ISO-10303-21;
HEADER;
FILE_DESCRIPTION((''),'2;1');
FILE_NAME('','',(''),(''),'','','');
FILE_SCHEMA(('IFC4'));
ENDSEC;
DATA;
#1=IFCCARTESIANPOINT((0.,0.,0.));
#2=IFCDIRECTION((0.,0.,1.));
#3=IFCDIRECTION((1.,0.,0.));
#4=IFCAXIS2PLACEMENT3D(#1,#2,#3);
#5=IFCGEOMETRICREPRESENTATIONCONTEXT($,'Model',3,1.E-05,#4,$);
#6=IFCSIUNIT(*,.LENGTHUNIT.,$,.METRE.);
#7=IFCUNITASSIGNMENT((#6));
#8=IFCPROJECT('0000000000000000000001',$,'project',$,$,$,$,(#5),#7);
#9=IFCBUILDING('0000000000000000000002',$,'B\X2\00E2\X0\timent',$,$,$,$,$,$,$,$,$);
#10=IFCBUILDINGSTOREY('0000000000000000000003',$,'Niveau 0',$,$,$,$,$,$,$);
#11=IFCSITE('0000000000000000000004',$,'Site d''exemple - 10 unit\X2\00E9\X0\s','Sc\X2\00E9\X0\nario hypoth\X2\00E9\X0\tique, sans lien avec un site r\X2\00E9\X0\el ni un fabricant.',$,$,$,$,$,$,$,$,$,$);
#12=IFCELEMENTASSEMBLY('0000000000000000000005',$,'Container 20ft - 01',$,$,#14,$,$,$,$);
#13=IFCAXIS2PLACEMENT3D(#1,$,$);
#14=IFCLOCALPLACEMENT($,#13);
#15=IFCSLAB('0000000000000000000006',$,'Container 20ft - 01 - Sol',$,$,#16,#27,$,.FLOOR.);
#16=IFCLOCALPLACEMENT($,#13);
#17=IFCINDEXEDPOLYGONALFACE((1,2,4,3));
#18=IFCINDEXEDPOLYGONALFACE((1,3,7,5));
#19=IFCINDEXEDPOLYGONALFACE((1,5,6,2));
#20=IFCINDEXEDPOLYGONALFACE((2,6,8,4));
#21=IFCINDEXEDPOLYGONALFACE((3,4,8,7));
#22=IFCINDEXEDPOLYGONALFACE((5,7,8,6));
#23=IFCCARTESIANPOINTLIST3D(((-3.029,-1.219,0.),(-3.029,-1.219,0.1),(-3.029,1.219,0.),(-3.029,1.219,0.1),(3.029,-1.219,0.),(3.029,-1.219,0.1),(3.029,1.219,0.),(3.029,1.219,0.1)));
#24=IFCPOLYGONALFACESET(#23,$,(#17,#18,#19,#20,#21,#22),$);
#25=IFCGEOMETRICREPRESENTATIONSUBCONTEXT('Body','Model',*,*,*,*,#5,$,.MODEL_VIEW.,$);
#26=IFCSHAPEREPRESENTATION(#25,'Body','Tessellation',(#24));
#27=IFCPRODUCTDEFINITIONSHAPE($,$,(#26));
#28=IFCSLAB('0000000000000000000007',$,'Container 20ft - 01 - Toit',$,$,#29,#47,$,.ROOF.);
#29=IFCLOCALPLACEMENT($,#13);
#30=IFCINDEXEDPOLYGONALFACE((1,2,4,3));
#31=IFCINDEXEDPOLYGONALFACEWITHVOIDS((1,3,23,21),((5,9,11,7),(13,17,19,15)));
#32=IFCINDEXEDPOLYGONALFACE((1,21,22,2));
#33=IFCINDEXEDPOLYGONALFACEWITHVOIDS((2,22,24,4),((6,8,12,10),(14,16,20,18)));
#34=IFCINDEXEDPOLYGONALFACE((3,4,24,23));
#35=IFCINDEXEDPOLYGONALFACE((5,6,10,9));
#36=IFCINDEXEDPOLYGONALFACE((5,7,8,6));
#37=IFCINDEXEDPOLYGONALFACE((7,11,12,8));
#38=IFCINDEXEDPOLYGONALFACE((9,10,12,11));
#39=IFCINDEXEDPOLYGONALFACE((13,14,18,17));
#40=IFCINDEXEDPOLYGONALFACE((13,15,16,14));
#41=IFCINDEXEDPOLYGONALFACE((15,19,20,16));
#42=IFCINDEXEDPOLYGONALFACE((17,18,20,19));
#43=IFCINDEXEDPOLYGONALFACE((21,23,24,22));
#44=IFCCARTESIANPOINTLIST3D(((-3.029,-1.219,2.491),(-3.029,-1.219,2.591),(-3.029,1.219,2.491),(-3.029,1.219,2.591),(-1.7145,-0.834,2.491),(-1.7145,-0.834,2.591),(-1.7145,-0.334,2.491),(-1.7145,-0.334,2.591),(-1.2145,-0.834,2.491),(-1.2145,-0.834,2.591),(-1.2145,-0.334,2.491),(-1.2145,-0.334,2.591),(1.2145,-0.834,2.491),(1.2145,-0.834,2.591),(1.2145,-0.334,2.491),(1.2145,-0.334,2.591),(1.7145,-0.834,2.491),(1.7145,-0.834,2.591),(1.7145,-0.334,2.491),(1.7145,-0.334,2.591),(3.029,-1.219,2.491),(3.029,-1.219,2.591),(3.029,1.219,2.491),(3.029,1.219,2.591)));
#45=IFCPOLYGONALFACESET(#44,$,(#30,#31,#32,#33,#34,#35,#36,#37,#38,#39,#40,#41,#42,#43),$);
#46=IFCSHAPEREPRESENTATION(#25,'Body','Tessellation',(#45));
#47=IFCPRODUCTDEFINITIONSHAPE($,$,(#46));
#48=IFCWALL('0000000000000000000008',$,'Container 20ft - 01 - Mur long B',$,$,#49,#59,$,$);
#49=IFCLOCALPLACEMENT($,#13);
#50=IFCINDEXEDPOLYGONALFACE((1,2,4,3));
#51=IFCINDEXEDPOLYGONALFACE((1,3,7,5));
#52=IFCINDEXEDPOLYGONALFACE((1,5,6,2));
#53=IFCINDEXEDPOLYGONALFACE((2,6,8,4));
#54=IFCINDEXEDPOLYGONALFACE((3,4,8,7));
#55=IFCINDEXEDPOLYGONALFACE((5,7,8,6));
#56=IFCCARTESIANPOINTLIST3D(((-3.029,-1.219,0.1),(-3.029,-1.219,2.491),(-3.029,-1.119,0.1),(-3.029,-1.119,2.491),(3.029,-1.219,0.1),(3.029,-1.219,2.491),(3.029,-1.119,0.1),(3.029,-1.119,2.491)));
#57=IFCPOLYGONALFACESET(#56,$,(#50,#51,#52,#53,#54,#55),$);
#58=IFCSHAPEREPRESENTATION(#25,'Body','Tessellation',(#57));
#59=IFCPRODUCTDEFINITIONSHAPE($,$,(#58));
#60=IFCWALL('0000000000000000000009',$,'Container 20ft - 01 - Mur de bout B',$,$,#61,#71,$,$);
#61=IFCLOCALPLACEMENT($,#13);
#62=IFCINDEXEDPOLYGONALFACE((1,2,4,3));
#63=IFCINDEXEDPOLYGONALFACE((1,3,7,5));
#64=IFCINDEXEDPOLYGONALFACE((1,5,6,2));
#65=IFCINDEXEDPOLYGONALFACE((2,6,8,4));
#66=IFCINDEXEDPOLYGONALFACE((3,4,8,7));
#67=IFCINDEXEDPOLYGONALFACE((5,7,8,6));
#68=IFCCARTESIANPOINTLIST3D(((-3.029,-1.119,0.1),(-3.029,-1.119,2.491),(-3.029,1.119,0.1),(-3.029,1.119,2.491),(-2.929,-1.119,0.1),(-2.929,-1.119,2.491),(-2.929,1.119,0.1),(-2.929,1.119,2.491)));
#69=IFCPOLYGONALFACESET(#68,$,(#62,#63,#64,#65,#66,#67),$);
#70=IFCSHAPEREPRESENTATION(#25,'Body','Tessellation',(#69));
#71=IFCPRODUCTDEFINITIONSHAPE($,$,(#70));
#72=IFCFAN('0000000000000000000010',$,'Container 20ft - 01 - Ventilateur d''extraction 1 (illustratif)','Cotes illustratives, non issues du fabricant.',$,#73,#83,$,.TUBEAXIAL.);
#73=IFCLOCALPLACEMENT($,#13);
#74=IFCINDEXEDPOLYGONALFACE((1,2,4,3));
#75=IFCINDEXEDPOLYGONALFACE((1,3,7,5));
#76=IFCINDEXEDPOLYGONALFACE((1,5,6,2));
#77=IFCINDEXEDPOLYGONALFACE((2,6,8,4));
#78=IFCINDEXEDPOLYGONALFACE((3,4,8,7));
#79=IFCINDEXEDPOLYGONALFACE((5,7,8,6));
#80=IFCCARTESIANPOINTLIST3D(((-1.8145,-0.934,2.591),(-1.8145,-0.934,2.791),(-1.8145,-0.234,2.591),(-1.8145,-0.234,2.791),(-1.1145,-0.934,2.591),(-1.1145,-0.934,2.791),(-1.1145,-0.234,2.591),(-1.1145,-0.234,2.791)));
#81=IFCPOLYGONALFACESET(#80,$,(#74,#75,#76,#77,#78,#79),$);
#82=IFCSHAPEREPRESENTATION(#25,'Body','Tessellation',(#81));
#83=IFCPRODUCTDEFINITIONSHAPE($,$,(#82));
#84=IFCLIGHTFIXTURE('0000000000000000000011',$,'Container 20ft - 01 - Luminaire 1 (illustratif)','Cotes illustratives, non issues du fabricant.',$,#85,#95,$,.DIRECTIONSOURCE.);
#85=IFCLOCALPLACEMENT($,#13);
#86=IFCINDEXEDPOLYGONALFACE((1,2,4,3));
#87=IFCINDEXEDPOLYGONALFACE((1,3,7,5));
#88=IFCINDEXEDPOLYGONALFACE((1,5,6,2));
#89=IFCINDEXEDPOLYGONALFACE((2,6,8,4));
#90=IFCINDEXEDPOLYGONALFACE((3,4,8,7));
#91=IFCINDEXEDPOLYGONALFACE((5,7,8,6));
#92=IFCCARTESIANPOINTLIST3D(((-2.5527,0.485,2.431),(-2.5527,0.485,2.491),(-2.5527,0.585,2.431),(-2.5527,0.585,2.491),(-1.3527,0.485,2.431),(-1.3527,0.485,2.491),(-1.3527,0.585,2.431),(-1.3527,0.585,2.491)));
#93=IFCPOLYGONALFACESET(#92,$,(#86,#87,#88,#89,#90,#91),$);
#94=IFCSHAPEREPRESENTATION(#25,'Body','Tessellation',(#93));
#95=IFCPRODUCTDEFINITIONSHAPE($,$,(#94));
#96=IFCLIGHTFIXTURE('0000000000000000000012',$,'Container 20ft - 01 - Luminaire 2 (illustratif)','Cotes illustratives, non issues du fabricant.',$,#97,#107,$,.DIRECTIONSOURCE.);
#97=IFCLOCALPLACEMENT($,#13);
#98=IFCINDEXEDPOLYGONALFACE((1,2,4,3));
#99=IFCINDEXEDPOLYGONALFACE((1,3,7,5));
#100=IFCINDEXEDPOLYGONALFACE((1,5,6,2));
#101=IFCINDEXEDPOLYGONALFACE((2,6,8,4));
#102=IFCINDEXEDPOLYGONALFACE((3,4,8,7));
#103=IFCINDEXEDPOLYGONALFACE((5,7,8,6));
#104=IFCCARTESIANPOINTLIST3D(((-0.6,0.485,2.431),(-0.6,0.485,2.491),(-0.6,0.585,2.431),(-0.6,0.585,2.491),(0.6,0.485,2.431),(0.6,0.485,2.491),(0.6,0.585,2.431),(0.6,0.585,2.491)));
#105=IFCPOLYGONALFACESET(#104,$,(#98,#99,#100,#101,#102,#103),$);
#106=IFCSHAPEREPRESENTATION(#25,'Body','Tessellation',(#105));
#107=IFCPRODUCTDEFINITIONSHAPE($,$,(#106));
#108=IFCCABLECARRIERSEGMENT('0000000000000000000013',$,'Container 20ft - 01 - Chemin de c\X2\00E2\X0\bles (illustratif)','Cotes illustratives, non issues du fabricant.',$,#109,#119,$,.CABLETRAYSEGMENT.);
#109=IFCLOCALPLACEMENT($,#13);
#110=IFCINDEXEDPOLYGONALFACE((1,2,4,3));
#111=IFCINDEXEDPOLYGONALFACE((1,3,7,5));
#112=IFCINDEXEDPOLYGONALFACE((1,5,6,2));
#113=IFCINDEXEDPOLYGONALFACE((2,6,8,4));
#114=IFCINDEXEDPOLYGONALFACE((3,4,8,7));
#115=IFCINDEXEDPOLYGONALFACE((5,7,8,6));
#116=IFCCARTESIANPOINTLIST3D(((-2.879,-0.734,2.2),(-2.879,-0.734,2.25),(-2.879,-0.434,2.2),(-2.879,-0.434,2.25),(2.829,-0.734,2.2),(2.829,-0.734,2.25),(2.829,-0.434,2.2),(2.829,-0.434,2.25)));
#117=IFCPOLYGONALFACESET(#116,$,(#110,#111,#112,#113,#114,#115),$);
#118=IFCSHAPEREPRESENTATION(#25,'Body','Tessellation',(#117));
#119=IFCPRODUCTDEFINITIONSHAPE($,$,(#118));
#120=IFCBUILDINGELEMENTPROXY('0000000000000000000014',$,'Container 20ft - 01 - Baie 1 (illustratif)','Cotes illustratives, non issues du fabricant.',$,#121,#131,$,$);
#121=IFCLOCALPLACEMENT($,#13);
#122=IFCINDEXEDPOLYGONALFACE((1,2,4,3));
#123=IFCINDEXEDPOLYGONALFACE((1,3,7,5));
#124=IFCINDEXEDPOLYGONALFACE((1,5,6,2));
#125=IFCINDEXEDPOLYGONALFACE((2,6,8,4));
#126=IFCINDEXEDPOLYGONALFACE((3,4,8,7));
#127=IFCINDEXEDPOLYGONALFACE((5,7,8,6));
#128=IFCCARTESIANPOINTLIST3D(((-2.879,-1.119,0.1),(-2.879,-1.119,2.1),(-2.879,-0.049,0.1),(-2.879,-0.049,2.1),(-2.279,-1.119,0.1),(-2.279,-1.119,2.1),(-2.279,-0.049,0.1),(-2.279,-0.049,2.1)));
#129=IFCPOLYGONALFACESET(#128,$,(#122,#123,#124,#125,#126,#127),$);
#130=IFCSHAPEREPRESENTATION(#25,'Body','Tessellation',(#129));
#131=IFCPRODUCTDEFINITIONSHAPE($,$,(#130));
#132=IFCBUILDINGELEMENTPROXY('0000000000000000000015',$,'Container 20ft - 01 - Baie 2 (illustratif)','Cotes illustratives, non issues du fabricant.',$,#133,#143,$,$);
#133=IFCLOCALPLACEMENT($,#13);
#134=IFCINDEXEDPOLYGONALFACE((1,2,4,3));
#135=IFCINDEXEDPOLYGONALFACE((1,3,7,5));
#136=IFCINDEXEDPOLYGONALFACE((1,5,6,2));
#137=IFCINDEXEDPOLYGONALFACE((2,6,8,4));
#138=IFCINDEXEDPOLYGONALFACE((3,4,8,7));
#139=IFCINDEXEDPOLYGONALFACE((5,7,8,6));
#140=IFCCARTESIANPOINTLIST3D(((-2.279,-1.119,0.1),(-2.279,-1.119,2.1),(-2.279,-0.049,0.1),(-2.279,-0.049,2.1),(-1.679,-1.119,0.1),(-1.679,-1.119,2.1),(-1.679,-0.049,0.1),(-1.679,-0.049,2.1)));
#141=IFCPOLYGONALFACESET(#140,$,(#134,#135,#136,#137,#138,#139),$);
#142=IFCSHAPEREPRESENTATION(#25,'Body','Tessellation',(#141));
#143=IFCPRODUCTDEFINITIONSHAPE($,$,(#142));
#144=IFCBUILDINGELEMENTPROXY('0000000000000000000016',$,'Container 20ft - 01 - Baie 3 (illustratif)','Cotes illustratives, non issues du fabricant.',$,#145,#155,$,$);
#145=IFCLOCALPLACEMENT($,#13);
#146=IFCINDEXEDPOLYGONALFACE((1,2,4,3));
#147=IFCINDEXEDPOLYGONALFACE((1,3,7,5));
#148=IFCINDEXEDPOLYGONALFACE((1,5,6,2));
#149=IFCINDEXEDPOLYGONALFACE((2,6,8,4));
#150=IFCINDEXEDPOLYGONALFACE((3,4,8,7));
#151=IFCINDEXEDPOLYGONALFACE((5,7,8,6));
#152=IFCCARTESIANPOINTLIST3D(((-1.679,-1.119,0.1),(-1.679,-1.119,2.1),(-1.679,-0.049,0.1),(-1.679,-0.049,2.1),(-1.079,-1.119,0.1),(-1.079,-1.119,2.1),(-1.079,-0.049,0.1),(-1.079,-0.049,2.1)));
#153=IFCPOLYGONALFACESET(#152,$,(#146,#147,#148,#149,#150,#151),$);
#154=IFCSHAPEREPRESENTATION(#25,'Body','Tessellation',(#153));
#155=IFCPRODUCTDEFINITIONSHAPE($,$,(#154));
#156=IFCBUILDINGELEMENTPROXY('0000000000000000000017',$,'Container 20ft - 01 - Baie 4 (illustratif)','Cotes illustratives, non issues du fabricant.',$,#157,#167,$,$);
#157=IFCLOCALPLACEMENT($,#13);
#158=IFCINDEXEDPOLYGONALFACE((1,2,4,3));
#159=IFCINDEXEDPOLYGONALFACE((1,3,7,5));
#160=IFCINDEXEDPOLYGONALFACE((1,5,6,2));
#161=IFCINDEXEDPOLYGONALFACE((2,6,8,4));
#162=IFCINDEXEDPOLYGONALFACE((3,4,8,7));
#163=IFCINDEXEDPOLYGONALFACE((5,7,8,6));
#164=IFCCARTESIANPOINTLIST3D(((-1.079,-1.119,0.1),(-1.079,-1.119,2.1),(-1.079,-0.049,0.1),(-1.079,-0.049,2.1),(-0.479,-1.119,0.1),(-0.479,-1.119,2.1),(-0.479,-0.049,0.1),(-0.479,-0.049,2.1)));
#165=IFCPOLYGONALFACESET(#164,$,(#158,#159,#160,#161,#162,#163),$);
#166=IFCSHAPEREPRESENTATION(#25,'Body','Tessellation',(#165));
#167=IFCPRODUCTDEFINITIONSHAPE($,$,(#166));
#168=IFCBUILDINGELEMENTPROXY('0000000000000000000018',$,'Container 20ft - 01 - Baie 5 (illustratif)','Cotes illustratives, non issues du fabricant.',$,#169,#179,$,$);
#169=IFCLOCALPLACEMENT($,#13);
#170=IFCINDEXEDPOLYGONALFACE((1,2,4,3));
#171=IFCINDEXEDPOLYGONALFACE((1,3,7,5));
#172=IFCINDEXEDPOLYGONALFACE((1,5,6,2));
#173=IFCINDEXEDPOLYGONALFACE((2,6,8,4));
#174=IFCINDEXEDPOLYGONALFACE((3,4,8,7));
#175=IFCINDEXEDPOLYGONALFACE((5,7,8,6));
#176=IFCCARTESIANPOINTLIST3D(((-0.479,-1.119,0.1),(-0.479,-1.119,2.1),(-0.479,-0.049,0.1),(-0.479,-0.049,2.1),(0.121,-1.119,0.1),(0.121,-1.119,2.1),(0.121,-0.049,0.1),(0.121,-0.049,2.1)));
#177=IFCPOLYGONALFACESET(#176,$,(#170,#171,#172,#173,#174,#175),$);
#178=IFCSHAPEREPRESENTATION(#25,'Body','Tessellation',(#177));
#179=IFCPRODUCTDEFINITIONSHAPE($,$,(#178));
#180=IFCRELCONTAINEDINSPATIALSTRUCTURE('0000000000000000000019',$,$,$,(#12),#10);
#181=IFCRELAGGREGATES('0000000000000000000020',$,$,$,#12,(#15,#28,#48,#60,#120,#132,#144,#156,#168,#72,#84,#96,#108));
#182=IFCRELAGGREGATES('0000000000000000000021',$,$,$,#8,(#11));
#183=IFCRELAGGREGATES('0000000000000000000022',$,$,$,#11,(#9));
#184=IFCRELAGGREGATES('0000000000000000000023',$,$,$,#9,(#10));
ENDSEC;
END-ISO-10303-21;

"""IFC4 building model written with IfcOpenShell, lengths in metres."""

from ifc_helpers import new_model, si_unit, frame, origin_with_axes, place, context, subcontext, project, spatial, rectangle, extrude, element, aggregate, save


model = new_model("IFC4")

# Units and contexts
model_context = context("Model", 3, precision=1e-05, world=origin_with_axes())
body_context = subcontext(model_context, "Body", "Model", "MODEL_VIEW")
ifc_project = project(units=[si_unit("LENGTHUNIT", "METRE")], contexts=[model_context])

# Site, building, storey
site = spatial("IfcSite", under=ifc_project, Name="Site d'exemple - 10 unités", Description="Scénario hypothétique, sans lien avec un site réel ni un fabricant.")
building = spatial("IfcBuilding", under=site, Name="Bâtiment")
storey = spatial("IfcBuildingStorey", under=building, Name="Niveau 0")

# Element assembly, slabs, openings, walls, fan, light fixtures, cable carrier segment, building element proxies
assembly = element("IfcElementAssembly", 1, inside=storey, Name="Container 20ft - 01")
slab_1_placement = place(None, origin_with_axes())
slab_1 = element("IfcSlab", 2, at=slab_1_placement, Name="Container 20ft - 01 - Sol", PredefinedType="FLOOR", context=body_context, shape_type="SweptSolid", body=[
    extrude(rectangle(XDim=6.058, YDim=2.438), origin_with_axes(), (0.0, 0.0, 1.0), 0.1),
])
slab_2_placement = place(None, frame((0.0, 0.0, 2.491), z_axis=(0.0, 0.0, 1.0), x_axis=(1.0, 0.0, 0.0)))
slab_2 = element("IfcSlab", 3, at=slab_2_placement, Name="Container 20ft - 01 - Toit", PredefinedType="ROOF", context=body_context, shape_type="SweptSolid", body=[
    extrude(rectangle(XDim=6.058, YDim=2.438), origin_with_axes(), (0.0, 0.0, 1.0), 0.1),
])
opening_1_placement = place(None, frame((-1.4645, -0.584, 2.441), z_axis=(0.0, 0.0, 1.0), x_axis=(1.0, 0.0, 0.0)))
element("IfcOpeningElement", 4, at=opening_1_placement, cuts=slab_2, PredefinedType="OPENING", context=body_context, shape_type="SweptSolid", body=[
    extrude(rectangle(XDim=0.5, YDim=0.5), origin_with_axes(), (0.0, 0.0, 1.0), 0.2),
])
opening_2_placement = place(None, frame((1.4645, -0.584, 2.441), z_axis=(0.0, 0.0, 1.0), x_axis=(1.0, 0.0, 0.0)))
element("IfcOpeningElement", 5, at=opening_2_placement, cuts=slab_2, PredefinedType="OPENING", context=body_context, shape_type="SweptSolid", body=[
    extrude(rectangle(XDim=0.5, YDim=0.5), origin_with_axes(), (0.0, 0.0, 1.0), 0.2),
])
wall_1_placement = place(None, frame((0.0, -1.169, 0.1), z_axis=(0.0, 0.0, 1.0), x_axis=(1.0, 0.0, 0.0)))
wall_1 = element("IfcWall", 6, at=wall_1_placement, Name="Container 20ft - 01 - Mur long B", context=body_context, shape_type="SweptSolid", body=[
    extrude(rectangle(XDim=6.058, YDim=0.1), origin_with_axes(), (0.0, 0.0, 1.0), 2.391),
])
wall_2_placement = place(None, frame((-2.979, 0.0, 0.1), z_axis=(0.0, 0.0, 1.0), x_axis=(1.0, 0.0, 0.0)))
wall_2 = element("IfcWall", 7, at=wall_2_placement, Name="Container 20ft - 01 - Mur de bout B", context=body_context, shape_type="SweptSolid", body=[
    extrude(rectangle(XDim=0.1, YDim=2.238), origin_with_axes(), (0.0, 0.0, 1.0), 2.391),
])
fan_placement = place(None, frame((-1.4645, -0.584, 2.591), z_axis=(0.0, 0.0, 1.0), x_axis=(1.0, 0.0, 0.0)))
fan = element("IfcFan", 8, at=fan_placement, Name="Container 20ft - 01 - Ventilateur d'extraction 1 (illustratif)", Description="Cotes illustratives, non issues du fabricant.", PredefinedType="TUBEAXIAL", context=body_context, shape_type="SweptSolid", body=[
    extrude(rectangle(XDim=0.7, YDim=0.7), origin_with_axes(), (0.0, 0.0, 1.0), 0.2),
])
light_fixture_1_placement = place(None, frame((-1.9527, 0.535, 2.431), z_axis=(0.0, 0.0, 1.0), x_axis=(1.0, 0.0, 0.0)))
light_fixture_1 = element("IfcLightFixture", 9, at=light_fixture_1_placement, Name="Container 20ft - 01 - Luminaire 1 (illustratif)", Description="Cotes illustratives, non issues du fabricant.", PredefinedType="DIRECTIONSOURCE", context=body_context, shape_type="SweptSolid", body=[
    extrude(rectangle(XDim=1.2, YDim=0.1), origin_with_axes(), (0.0, 0.0, 1.0), 0.06),
])
light_fixture_2_placement = place(None, frame((0.0, 0.535, 2.431), z_axis=(0.0, 0.0, 1.0), x_axis=(1.0, 0.0, 0.0)))
light_fixture_2 = element("IfcLightFixture", 10, at=light_fixture_2_placement, Name="Container 20ft - 01 - Luminaire 2 (illustratif)", Description="Cotes illustratives, non issues du fabricant.", PredefinedType="DIRECTIONSOURCE", context=body_context, shape_type="SweptSolid", body=[
    extrude(rectangle(XDim=1.2, YDim=0.1), origin_with_axes(), (0.0, 0.0, 1.0), 0.06),
])
cable_carrier_segment_placement = place(None, frame((-0.025, -0.584, 2.2), z_axis=(0.0, 0.0, 1.0), x_axis=(1.0, 0.0, 0.0)))
cable_carrier_segment = element("IfcCableCarrierSegment", 11, at=cable_carrier_segment_placement, Name="Container 20ft - 01 - Chemin de câbles (illustratif)", Description="Cotes illustratives, non issues du fabricant.", PredefinedType="CABLETRAYSEGMENT", context=body_context, shape_type="SweptSolid", body=[
    extrude(rectangle(XDim=5.708, YDim=0.3), origin_with_axes(), (0.0, 0.0, 1.0), 0.05),
])
proxy_1_placement = place(None, frame((-2.579, -0.584, 0.1), z_axis=(0.0, 0.0, 1.0), x_axis=(1.0, 0.0, 0.0)))
proxy_1 = element("IfcBuildingElementProxy", 12, at=proxy_1_placement, Name="Container 20ft - 01 - Baie 1 (illustratif)", Description="Cotes illustratives, non issues du fabricant.", context=body_context, shape_type="SweptSolid", body=[
    extrude(rectangle(XDim=0.6, YDim=1.07), origin_with_axes(), (0.0, 0.0, 1.0), 2.0),
])
proxy_2_placement = place(None, frame((-1.979, -0.584, 0.1), z_axis=(0.0, 0.0, 1.0), x_axis=(1.0, 0.0, 0.0)))
proxy_2 = element("IfcBuildingElementProxy", 13, at=proxy_2_placement, Name="Container 20ft - 01 - Baie 2 (illustratif)", Description="Cotes illustratives, non issues du fabricant.", context=body_context, shape_type="SweptSolid", body=[
    extrude(rectangle(XDim=0.6, YDim=1.07), origin_with_axes(), (0.0, 0.0, 1.0), 2.0),
])
proxy_3_placement = place(None, frame((-1.379, -0.584, 0.1), z_axis=(0.0, 0.0, 1.0), x_axis=(1.0, 0.0, 0.0)))
proxy_3 = element("IfcBuildingElementProxy", 14, at=proxy_3_placement, Name="Container 20ft - 01 - Baie 3 (illustratif)", Description="Cotes illustratives, non issues du fabricant.", context=body_context, shape_type="SweptSolid", body=[
    extrude(rectangle(XDim=0.6, YDim=1.07), origin_with_axes(), (0.0, 0.0, 1.0), 2.0),
])
proxy_4_placement = place(None, frame((-0.779, -0.584, 0.1), z_axis=(0.0, 0.0, 1.0), x_axis=(1.0, 0.0, 0.0)))
proxy_4 = element("IfcBuildingElementProxy", 15, at=proxy_4_placement, Name="Container 20ft - 01 - Baie 4 (illustratif)", Description="Cotes illustratives, non issues du fabricant.", context=body_context, shape_type="SweptSolid", body=[
    extrude(rectangle(XDim=0.6, YDim=1.07), origin_with_axes(), (0.0, 0.0, 1.0), 2.0),
])
proxy_5_placement = place(None, frame((-0.179, -0.584, 0.1), z_axis=(0.0, 0.0, 1.0), x_axis=(1.0, 0.0, 0.0)))
proxy_5 = element("IfcBuildingElementProxy", 16, at=proxy_5_placement, Name="Container 20ft - 01 - Baie 5 (illustratif)", Description="Cotes illustratives, non issues du fabricant.", context=body_context, shape_type="SweptSolid", body=[
    extrude(rectangle(XDim=0.6, YDim=1.07), origin_with_axes(), (0.0, 0.0, 1.0), 2.0),
])
aggregate(assembly, [slab_1, slab_2, wall_1, wall_2, proxy_1, proxy_2, proxy_3, proxy_4, proxy_5, fan, light_fixture_1, light_fixture_2, cable_carrier_segment])

save(model, "model.ifc")
